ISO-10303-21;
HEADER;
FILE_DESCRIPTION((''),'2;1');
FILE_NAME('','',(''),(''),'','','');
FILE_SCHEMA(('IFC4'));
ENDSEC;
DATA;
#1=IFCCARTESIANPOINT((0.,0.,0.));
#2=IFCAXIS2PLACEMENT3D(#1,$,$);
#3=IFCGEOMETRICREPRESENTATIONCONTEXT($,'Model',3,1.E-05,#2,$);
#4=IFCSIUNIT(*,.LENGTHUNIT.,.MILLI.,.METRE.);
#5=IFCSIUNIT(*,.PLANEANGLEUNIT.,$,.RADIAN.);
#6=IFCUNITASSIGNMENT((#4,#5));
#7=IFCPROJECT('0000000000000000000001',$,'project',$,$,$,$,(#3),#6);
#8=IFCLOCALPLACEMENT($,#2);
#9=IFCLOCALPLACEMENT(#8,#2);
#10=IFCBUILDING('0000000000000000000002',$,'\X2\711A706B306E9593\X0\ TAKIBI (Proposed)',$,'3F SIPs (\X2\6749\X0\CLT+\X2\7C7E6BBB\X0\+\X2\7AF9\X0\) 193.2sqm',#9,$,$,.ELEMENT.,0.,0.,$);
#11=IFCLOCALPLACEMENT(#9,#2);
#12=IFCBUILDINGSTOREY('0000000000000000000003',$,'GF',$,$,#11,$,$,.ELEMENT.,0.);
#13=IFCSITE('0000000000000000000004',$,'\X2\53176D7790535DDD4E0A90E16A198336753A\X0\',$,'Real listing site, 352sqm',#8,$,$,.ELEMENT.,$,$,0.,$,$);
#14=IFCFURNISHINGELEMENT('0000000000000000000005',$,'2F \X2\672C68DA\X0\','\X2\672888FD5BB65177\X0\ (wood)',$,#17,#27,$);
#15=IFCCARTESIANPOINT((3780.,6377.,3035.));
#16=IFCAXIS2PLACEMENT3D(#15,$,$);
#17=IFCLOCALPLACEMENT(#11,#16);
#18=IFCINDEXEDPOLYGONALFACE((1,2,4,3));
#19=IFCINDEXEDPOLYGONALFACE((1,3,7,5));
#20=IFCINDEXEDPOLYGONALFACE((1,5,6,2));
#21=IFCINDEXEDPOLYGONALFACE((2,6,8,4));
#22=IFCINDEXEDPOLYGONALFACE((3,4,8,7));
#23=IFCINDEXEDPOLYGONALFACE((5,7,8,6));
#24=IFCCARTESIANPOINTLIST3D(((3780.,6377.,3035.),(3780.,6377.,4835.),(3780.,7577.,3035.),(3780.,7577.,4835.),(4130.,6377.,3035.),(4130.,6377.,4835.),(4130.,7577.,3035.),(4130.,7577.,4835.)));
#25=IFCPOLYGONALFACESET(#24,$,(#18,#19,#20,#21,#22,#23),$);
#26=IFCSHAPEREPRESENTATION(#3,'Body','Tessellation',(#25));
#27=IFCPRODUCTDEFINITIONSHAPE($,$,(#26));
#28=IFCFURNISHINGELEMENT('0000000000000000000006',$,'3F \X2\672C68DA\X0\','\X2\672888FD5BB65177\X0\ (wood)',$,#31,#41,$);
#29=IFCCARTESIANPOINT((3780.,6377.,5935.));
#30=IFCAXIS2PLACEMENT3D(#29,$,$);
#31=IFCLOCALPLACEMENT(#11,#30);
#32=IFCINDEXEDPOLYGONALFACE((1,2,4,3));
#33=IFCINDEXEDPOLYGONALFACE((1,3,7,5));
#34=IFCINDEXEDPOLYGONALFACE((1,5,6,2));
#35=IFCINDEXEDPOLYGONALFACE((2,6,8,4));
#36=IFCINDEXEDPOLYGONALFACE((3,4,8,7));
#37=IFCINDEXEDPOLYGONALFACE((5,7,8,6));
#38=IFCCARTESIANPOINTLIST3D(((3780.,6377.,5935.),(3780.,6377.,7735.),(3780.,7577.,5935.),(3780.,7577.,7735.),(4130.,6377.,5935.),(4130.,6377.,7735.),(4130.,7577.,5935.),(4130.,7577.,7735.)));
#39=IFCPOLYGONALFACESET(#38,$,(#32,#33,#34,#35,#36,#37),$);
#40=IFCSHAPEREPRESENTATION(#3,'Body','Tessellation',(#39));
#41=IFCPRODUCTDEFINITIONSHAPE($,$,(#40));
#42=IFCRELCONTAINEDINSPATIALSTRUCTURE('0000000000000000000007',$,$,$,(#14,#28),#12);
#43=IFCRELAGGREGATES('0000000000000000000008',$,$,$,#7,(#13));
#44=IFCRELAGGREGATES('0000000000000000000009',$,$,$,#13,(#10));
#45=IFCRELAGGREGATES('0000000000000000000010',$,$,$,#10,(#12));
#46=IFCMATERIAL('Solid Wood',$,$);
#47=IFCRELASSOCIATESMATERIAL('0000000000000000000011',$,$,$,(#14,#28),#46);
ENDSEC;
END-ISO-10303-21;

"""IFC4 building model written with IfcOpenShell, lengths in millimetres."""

from ifc_helpers import new_model, si_unit, frame, frame_2d, origin, place, context, project, spatial, rectangle, extrude, material, element, save


model = new_model("IFC4")

# Units and contexts
model_context = context("Model", 3, precision=1e-05, world=origin())
ifc_project = project(units=[si_unit("LENGTHUNIT", "METRE", prefix="MILLI"), si_unit("PLANEANGLEUNIT", "RADIAN")], contexts=[model_context])

# Site, building, storey
site_placement = place(None, origin())
site = spatial("IfcSite", under=ifc_project, at=site_placement, Name="北海道川上郡標茶町", ObjectType="Real listing site, 352sqm", CompositionType="ELEMENT", RefElevation=0.0)
building_placement = place(site_placement, origin())
building = spatial("IfcBuilding", under=site, at=building_placement, Name="焚火の間 TAKIBI (Proposed)", ObjectType="3F SIPs (杉CLT+籾殻+竹) 193.2sqm", CompositionType="ELEMENT", ElevationOfRefHeight=0.0, ElevationOfTerrain=0.0)
storey_placement = place(building_placement, origin())
storey = spatial("IfcBuildingStorey", under=building, at=storey_placement, Name="GF", CompositionType="ELEMENT", Elevation=0.0)

# Shared definitions
ifc_material_1 = material(Name="Solid Wood")

# Furnishing elements
furnishing_1_placement = place(storey_placement, frame((3780.0, 6377.0, 3035.0)))
element("IfcFurnishingElement", 1, at=furnishing_1_placement, inside=storey, material=ifc_material_1, Name="2F 本棚", Description="木製家具 (wood)", context=model_context, shape_type="SweptSolid", body=[
    extrude(rectangle(XDim=350.0, YDim=1200.0, at=frame_2d((175.0, 600.0))), frame((3780.0, 6377.0, 3035.0)), (0.0, 0.0, 1.0), 1800.0),
])
furnishing_2_placement = place(storey_placement, frame((3780.0, 6377.0, 5935.0)))
element("IfcFurnishingElement", 2, at=furnishing_2_placement, inside=storey, material=ifc_material_1, Name="3F 本棚", Description="木製家具 (wood)", context=model_context, shape_type="SweptSolid", body=[
    extrude(rectangle(XDim=350.0, YDim=1200.0, at=frame_2d((175.0, 600.0))), frame((3780.0, 6377.0, 5935.0)), (0.0, 0.0, 1.0), 1800.0),
])

save(model, "model.ifc")
